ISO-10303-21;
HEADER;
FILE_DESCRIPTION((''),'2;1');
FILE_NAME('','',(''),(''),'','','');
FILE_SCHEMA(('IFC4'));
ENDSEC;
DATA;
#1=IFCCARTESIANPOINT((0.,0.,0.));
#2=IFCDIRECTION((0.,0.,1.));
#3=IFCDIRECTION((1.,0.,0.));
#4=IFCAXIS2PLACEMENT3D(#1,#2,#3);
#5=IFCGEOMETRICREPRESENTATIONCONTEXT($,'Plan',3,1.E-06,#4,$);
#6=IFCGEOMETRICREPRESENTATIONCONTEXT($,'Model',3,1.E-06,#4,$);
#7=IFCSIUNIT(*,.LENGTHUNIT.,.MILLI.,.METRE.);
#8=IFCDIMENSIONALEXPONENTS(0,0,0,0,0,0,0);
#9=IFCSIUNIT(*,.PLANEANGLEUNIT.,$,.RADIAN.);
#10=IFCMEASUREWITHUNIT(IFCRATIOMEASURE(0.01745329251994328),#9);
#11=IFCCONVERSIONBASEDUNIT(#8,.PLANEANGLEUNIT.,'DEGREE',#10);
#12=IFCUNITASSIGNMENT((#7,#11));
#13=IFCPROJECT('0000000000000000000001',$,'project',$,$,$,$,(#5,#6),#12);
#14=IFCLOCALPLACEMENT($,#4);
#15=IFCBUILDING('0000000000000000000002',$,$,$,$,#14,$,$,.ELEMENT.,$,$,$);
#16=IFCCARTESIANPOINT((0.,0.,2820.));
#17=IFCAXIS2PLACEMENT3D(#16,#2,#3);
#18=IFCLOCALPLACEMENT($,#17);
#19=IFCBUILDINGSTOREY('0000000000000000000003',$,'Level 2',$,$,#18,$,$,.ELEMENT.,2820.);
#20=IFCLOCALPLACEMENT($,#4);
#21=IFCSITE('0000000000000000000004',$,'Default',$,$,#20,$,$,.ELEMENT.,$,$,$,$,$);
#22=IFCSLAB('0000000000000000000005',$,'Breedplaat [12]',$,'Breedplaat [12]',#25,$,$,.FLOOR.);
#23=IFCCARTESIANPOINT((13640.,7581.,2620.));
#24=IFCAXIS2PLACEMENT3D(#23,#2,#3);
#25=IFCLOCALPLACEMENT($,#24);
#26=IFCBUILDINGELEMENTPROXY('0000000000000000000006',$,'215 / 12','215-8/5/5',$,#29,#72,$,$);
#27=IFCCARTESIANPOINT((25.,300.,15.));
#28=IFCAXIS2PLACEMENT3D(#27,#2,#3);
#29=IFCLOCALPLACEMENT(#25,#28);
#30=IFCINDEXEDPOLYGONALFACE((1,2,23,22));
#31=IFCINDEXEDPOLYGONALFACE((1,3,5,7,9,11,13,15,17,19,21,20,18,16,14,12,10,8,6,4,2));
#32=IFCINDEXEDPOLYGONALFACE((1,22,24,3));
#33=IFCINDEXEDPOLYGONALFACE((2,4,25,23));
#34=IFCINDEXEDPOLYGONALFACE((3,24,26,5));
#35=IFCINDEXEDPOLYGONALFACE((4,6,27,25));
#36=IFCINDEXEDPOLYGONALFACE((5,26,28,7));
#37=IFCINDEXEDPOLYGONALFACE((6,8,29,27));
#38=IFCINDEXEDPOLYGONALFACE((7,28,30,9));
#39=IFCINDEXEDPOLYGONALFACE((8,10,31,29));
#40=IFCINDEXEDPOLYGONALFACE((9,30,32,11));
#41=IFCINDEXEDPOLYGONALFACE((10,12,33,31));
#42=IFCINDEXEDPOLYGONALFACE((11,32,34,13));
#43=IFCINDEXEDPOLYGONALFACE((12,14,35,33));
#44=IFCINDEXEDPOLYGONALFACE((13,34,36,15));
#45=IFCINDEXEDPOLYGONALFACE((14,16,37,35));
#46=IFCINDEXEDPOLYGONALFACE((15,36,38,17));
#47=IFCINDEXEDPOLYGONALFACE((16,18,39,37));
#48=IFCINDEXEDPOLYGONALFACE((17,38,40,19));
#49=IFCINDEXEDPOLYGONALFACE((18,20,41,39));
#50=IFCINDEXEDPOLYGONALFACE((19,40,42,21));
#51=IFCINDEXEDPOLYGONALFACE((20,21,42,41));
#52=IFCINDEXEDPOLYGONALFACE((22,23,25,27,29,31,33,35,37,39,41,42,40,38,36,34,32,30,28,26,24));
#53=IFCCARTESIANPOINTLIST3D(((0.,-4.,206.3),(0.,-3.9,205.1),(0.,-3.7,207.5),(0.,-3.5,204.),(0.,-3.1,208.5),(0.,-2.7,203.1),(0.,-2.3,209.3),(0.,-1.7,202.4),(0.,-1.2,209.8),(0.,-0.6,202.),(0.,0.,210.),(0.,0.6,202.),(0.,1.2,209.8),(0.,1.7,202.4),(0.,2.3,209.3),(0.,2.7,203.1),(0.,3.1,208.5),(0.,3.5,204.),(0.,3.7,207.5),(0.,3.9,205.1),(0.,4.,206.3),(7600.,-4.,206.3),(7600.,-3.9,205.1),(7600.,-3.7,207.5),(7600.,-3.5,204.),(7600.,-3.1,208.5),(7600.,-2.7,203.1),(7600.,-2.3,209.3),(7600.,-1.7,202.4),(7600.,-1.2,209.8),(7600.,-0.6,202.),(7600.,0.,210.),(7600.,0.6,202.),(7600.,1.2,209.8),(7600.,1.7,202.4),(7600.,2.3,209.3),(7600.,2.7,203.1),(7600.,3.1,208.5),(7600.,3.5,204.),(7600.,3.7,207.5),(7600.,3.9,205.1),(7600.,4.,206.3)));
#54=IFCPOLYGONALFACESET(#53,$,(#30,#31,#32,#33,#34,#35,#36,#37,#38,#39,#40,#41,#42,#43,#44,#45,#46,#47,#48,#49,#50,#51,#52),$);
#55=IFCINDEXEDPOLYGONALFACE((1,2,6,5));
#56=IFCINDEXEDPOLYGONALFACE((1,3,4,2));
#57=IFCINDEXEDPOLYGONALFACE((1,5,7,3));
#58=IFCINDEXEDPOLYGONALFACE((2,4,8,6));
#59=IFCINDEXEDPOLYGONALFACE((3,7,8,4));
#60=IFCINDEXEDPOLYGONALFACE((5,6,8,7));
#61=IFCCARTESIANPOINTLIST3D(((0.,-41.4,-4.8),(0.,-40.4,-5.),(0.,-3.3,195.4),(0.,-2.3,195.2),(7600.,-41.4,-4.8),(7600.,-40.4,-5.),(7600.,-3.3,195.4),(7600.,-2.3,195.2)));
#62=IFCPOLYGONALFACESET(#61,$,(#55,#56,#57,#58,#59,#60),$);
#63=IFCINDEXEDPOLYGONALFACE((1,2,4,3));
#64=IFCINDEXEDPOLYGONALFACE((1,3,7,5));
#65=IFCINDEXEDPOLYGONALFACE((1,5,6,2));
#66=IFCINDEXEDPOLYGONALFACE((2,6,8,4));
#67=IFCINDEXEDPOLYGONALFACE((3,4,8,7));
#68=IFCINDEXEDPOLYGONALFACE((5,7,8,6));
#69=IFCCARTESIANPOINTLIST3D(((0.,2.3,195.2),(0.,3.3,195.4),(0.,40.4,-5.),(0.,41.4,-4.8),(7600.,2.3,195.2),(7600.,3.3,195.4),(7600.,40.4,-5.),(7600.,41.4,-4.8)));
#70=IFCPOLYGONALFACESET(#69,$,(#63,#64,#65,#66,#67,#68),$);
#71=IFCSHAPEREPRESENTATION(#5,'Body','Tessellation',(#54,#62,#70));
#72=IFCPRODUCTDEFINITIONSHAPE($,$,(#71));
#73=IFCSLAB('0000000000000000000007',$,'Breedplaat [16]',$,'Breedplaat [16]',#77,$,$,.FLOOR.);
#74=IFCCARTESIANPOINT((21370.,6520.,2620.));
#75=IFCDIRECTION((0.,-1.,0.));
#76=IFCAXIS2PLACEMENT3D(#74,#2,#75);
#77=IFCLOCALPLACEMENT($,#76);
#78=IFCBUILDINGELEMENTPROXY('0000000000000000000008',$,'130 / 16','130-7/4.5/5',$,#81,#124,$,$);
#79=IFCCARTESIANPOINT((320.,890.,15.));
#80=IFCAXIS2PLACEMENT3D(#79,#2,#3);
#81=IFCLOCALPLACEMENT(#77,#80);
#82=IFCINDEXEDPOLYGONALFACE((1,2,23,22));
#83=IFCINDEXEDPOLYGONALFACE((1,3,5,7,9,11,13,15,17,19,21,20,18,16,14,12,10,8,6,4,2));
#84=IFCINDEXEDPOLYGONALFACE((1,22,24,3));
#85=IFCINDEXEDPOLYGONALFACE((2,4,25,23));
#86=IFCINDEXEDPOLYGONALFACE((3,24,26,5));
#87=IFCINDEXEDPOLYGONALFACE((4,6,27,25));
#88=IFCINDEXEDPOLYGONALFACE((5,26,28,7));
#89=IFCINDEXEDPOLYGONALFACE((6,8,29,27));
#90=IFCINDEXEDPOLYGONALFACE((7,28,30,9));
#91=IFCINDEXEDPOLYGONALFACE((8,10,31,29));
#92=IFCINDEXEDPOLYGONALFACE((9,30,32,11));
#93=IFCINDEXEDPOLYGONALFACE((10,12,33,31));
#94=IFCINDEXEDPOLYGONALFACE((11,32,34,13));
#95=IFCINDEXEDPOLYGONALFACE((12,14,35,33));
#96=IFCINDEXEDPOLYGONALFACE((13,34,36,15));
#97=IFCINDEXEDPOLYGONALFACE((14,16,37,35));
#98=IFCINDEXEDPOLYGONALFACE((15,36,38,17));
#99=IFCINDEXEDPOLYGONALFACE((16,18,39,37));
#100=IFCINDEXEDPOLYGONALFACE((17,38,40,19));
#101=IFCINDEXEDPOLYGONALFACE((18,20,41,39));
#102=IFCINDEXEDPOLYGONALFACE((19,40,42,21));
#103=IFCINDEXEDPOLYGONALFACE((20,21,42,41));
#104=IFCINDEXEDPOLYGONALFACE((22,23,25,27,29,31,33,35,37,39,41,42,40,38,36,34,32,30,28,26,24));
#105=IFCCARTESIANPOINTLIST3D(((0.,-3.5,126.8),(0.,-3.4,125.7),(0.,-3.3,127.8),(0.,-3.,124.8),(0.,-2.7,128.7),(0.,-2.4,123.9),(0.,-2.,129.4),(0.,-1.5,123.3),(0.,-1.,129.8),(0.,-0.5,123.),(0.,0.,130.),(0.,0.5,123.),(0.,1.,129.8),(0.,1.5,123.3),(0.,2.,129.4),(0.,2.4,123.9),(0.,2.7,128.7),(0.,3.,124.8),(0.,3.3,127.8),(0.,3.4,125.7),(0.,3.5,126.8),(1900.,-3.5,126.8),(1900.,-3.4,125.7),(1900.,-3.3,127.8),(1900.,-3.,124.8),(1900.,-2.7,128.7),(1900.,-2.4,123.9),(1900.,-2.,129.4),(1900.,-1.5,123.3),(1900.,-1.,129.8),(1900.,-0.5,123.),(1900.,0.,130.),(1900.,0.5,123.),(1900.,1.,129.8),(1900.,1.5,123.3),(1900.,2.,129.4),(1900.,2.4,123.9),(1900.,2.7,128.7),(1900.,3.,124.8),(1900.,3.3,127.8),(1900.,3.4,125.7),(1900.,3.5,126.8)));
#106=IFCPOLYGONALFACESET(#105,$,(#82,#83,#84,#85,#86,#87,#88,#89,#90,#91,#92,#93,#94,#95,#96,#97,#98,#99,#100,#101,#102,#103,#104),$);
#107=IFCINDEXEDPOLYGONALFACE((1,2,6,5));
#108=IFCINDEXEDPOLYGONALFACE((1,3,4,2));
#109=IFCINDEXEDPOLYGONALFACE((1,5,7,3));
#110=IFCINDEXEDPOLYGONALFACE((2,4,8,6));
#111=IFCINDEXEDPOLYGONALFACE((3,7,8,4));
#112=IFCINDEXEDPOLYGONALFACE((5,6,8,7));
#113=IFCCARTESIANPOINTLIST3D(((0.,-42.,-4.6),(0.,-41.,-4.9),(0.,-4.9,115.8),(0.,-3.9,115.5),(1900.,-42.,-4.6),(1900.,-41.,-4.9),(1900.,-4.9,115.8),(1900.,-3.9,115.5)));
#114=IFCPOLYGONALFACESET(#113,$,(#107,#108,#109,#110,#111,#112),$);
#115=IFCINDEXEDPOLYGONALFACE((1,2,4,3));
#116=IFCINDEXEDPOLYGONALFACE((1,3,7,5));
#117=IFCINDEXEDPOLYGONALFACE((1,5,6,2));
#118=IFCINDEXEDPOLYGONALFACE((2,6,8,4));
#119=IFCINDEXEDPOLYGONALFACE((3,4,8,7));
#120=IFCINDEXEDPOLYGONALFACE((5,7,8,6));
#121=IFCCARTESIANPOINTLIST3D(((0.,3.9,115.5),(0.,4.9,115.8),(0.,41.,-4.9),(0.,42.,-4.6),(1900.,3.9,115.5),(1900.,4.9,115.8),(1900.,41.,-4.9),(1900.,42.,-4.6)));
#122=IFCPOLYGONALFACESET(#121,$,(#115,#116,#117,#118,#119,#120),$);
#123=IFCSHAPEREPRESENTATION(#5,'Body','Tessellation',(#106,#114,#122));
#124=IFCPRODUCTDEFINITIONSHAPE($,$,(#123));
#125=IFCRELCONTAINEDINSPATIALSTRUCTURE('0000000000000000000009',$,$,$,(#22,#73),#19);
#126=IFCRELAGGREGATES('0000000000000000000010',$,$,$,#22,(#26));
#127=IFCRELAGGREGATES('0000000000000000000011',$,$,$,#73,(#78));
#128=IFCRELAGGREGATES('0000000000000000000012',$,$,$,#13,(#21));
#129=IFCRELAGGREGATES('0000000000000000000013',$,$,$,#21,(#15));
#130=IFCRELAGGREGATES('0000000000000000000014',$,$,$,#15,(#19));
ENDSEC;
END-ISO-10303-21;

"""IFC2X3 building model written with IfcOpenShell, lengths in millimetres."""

from ifc_helpers import new_model, entity, si_unit, converted_unit, frame, origin_with_axes, origin_2d_with_axis, place, context, project, spatial, rectangle, circle, extrude, element, aggregate, save


model = new_model("IFC2X3")

# Units and contexts
plan_context = context("Plan", 3, precision=1e-06, world=origin_with_axes())
model_context = context("Model", 3, precision=1e-06, world=origin_with_axes())
ifc_project = project(units=[si_unit("LENGTHUNIT", "METRE", prefix="MILLI"), converted_unit("PLANEANGLEUNIT", "DEGREE", entity("IfcRatioMeasure", 0.01745329251994328), si_unit("PLANEANGLEUNIT", "RADIAN"), dimensions=[0, 0, 0, 0, 0, 0, 0])], contexts=[plan_context, model_context])

# Site, building, storey
site_placement = place(None, origin_with_axes())
site = spatial("IfcSite", under=ifc_project, at=site_placement, Name="Default", CompositionType="ELEMENT")
building_placement = place(None, origin_with_axes())
building = spatial("IfcBuilding", under=site, at=building_placement, CompositionType="ELEMENT")
storey_placement = place(None, frame((0.0, 0.0, 2820.0), z_axis=(0.0, 0.0, 1.0), x_axis=(1.0, 0.0, 0.0)))
storey = spatial("IfcBuildingStorey", under=building, at=storey_placement, Name="Level 2", CompositionType="ELEMENT", Elevation=2820.0)

# Slab, building element proxy
slab_1_placement = place(None, frame((13640.0, 7581.0, 2620.0), z_axis=(0.0, 0.0, 1.0), x_axis=(1.0, 0.0, 0.0)))
slab_1 = element("IfcSlab", 1, at=slab_1_placement, inside=storey, Name="Breedplaat [12]", ObjectType="Breedplaat [12]", PredefinedType="FLOOR")
proxy_1_placement = place(slab_1_placement, frame((25.0, 300.0, 15.0), z_axis=(0.0, 0.0, 1.0), x_axis=(1.0, 0.0, 0.0)))
proxy_1 = element("IfcBuildingElementProxy", 2, at=proxy_1_placement, Name="215 / 12", Description="215-8/5/5", context=plan_context, shape_type="SweptSolid", body=[
    extrude(circle(Radius=4.0, at=origin_2d_with_axis()), frame((0.0, 0.0, 206.0), z_axis=(1.0, 0.0, 0.0), x_axis=(0.0, 0.0, 1.0)), (0.0, 0.0, 1.0), 7600.0),
    extrude(rectangle(XDim=203.8, YDim=1.0, at=origin_2d_with_axis()), frame((0.0, -21.9, 95.2), z_axis=(1.0, 0.0, 0.0), x_axis=(0.0, 0.187112, 0.982339)), (0.0, 0.0, 1.0), 7600.0),
    extrude(rectangle(XDim=203.8, YDim=1.0, at=origin_2d_with_axis()), frame((0.0, 21.9, 95.2), z_axis=(1.0, 0.0, 0.0), x_axis=(0.0, -0.187112, 0.982339)), (0.0, 0.0, 1.0), 7600.0),
])
aggregate(slab_1, [proxy_1])

# Slab, building element proxy
slab_2_placement = place(None, frame((21370.0, 6520.0, 2620.0), z_axis=(0.0, 0.0, 1.0), x_axis=(0.0, -1.0, 0.0)))
slab_2 = element("IfcSlab", 3, at=slab_2_placement, inside=storey, Name="Breedplaat [16]", ObjectType="Breedplaat [16]", PredefinedType="FLOOR")
proxy_2_placement = place(slab_2_placement, frame((320.0, 890.0, 15.0), z_axis=(0.0, 0.0, 1.0), x_axis=(1.0, 0.0, 0.0)))
proxy_2 = element("IfcBuildingElementProxy", 4, at=proxy_2_placement, Name="130 / 16", Description="130-7/4.5/5", context=plan_context, shape_type="SweptSolid", body=[
    extrude(circle(Radius=3.5, at=origin_2d_with_axis()), frame((0.0, 0.0, 126.5), z_axis=(1.0, 0.0, 0.0), x_axis=(0.0, 0.0, 1.0)), (0.0, 0.0, 1.0), 1900.0),
    extrude(rectangle(XDim=126.0, YDim=1.0, at=origin_2d_with_axis()), frame((0.0, -22.9, 55.4), z_axis=(1.0, 0.0, 0.0), x_axis=(0.0, 0.294086, 0.955779)), (0.0, 0.0, 1.0), 1900.0),
    extrude(rectangle(XDim=126.0, YDim=1.0, at=origin_2d_with_axis()), frame((0.0, 22.9, 55.4), z_axis=(1.0, 0.0, 0.0), x_axis=(0.0, -0.294086, 0.955779)), (0.0, 0.0, 1.0), 1900.0),
])
aggregate(slab_2, [proxy_2])

save(model, "model.ifc")
